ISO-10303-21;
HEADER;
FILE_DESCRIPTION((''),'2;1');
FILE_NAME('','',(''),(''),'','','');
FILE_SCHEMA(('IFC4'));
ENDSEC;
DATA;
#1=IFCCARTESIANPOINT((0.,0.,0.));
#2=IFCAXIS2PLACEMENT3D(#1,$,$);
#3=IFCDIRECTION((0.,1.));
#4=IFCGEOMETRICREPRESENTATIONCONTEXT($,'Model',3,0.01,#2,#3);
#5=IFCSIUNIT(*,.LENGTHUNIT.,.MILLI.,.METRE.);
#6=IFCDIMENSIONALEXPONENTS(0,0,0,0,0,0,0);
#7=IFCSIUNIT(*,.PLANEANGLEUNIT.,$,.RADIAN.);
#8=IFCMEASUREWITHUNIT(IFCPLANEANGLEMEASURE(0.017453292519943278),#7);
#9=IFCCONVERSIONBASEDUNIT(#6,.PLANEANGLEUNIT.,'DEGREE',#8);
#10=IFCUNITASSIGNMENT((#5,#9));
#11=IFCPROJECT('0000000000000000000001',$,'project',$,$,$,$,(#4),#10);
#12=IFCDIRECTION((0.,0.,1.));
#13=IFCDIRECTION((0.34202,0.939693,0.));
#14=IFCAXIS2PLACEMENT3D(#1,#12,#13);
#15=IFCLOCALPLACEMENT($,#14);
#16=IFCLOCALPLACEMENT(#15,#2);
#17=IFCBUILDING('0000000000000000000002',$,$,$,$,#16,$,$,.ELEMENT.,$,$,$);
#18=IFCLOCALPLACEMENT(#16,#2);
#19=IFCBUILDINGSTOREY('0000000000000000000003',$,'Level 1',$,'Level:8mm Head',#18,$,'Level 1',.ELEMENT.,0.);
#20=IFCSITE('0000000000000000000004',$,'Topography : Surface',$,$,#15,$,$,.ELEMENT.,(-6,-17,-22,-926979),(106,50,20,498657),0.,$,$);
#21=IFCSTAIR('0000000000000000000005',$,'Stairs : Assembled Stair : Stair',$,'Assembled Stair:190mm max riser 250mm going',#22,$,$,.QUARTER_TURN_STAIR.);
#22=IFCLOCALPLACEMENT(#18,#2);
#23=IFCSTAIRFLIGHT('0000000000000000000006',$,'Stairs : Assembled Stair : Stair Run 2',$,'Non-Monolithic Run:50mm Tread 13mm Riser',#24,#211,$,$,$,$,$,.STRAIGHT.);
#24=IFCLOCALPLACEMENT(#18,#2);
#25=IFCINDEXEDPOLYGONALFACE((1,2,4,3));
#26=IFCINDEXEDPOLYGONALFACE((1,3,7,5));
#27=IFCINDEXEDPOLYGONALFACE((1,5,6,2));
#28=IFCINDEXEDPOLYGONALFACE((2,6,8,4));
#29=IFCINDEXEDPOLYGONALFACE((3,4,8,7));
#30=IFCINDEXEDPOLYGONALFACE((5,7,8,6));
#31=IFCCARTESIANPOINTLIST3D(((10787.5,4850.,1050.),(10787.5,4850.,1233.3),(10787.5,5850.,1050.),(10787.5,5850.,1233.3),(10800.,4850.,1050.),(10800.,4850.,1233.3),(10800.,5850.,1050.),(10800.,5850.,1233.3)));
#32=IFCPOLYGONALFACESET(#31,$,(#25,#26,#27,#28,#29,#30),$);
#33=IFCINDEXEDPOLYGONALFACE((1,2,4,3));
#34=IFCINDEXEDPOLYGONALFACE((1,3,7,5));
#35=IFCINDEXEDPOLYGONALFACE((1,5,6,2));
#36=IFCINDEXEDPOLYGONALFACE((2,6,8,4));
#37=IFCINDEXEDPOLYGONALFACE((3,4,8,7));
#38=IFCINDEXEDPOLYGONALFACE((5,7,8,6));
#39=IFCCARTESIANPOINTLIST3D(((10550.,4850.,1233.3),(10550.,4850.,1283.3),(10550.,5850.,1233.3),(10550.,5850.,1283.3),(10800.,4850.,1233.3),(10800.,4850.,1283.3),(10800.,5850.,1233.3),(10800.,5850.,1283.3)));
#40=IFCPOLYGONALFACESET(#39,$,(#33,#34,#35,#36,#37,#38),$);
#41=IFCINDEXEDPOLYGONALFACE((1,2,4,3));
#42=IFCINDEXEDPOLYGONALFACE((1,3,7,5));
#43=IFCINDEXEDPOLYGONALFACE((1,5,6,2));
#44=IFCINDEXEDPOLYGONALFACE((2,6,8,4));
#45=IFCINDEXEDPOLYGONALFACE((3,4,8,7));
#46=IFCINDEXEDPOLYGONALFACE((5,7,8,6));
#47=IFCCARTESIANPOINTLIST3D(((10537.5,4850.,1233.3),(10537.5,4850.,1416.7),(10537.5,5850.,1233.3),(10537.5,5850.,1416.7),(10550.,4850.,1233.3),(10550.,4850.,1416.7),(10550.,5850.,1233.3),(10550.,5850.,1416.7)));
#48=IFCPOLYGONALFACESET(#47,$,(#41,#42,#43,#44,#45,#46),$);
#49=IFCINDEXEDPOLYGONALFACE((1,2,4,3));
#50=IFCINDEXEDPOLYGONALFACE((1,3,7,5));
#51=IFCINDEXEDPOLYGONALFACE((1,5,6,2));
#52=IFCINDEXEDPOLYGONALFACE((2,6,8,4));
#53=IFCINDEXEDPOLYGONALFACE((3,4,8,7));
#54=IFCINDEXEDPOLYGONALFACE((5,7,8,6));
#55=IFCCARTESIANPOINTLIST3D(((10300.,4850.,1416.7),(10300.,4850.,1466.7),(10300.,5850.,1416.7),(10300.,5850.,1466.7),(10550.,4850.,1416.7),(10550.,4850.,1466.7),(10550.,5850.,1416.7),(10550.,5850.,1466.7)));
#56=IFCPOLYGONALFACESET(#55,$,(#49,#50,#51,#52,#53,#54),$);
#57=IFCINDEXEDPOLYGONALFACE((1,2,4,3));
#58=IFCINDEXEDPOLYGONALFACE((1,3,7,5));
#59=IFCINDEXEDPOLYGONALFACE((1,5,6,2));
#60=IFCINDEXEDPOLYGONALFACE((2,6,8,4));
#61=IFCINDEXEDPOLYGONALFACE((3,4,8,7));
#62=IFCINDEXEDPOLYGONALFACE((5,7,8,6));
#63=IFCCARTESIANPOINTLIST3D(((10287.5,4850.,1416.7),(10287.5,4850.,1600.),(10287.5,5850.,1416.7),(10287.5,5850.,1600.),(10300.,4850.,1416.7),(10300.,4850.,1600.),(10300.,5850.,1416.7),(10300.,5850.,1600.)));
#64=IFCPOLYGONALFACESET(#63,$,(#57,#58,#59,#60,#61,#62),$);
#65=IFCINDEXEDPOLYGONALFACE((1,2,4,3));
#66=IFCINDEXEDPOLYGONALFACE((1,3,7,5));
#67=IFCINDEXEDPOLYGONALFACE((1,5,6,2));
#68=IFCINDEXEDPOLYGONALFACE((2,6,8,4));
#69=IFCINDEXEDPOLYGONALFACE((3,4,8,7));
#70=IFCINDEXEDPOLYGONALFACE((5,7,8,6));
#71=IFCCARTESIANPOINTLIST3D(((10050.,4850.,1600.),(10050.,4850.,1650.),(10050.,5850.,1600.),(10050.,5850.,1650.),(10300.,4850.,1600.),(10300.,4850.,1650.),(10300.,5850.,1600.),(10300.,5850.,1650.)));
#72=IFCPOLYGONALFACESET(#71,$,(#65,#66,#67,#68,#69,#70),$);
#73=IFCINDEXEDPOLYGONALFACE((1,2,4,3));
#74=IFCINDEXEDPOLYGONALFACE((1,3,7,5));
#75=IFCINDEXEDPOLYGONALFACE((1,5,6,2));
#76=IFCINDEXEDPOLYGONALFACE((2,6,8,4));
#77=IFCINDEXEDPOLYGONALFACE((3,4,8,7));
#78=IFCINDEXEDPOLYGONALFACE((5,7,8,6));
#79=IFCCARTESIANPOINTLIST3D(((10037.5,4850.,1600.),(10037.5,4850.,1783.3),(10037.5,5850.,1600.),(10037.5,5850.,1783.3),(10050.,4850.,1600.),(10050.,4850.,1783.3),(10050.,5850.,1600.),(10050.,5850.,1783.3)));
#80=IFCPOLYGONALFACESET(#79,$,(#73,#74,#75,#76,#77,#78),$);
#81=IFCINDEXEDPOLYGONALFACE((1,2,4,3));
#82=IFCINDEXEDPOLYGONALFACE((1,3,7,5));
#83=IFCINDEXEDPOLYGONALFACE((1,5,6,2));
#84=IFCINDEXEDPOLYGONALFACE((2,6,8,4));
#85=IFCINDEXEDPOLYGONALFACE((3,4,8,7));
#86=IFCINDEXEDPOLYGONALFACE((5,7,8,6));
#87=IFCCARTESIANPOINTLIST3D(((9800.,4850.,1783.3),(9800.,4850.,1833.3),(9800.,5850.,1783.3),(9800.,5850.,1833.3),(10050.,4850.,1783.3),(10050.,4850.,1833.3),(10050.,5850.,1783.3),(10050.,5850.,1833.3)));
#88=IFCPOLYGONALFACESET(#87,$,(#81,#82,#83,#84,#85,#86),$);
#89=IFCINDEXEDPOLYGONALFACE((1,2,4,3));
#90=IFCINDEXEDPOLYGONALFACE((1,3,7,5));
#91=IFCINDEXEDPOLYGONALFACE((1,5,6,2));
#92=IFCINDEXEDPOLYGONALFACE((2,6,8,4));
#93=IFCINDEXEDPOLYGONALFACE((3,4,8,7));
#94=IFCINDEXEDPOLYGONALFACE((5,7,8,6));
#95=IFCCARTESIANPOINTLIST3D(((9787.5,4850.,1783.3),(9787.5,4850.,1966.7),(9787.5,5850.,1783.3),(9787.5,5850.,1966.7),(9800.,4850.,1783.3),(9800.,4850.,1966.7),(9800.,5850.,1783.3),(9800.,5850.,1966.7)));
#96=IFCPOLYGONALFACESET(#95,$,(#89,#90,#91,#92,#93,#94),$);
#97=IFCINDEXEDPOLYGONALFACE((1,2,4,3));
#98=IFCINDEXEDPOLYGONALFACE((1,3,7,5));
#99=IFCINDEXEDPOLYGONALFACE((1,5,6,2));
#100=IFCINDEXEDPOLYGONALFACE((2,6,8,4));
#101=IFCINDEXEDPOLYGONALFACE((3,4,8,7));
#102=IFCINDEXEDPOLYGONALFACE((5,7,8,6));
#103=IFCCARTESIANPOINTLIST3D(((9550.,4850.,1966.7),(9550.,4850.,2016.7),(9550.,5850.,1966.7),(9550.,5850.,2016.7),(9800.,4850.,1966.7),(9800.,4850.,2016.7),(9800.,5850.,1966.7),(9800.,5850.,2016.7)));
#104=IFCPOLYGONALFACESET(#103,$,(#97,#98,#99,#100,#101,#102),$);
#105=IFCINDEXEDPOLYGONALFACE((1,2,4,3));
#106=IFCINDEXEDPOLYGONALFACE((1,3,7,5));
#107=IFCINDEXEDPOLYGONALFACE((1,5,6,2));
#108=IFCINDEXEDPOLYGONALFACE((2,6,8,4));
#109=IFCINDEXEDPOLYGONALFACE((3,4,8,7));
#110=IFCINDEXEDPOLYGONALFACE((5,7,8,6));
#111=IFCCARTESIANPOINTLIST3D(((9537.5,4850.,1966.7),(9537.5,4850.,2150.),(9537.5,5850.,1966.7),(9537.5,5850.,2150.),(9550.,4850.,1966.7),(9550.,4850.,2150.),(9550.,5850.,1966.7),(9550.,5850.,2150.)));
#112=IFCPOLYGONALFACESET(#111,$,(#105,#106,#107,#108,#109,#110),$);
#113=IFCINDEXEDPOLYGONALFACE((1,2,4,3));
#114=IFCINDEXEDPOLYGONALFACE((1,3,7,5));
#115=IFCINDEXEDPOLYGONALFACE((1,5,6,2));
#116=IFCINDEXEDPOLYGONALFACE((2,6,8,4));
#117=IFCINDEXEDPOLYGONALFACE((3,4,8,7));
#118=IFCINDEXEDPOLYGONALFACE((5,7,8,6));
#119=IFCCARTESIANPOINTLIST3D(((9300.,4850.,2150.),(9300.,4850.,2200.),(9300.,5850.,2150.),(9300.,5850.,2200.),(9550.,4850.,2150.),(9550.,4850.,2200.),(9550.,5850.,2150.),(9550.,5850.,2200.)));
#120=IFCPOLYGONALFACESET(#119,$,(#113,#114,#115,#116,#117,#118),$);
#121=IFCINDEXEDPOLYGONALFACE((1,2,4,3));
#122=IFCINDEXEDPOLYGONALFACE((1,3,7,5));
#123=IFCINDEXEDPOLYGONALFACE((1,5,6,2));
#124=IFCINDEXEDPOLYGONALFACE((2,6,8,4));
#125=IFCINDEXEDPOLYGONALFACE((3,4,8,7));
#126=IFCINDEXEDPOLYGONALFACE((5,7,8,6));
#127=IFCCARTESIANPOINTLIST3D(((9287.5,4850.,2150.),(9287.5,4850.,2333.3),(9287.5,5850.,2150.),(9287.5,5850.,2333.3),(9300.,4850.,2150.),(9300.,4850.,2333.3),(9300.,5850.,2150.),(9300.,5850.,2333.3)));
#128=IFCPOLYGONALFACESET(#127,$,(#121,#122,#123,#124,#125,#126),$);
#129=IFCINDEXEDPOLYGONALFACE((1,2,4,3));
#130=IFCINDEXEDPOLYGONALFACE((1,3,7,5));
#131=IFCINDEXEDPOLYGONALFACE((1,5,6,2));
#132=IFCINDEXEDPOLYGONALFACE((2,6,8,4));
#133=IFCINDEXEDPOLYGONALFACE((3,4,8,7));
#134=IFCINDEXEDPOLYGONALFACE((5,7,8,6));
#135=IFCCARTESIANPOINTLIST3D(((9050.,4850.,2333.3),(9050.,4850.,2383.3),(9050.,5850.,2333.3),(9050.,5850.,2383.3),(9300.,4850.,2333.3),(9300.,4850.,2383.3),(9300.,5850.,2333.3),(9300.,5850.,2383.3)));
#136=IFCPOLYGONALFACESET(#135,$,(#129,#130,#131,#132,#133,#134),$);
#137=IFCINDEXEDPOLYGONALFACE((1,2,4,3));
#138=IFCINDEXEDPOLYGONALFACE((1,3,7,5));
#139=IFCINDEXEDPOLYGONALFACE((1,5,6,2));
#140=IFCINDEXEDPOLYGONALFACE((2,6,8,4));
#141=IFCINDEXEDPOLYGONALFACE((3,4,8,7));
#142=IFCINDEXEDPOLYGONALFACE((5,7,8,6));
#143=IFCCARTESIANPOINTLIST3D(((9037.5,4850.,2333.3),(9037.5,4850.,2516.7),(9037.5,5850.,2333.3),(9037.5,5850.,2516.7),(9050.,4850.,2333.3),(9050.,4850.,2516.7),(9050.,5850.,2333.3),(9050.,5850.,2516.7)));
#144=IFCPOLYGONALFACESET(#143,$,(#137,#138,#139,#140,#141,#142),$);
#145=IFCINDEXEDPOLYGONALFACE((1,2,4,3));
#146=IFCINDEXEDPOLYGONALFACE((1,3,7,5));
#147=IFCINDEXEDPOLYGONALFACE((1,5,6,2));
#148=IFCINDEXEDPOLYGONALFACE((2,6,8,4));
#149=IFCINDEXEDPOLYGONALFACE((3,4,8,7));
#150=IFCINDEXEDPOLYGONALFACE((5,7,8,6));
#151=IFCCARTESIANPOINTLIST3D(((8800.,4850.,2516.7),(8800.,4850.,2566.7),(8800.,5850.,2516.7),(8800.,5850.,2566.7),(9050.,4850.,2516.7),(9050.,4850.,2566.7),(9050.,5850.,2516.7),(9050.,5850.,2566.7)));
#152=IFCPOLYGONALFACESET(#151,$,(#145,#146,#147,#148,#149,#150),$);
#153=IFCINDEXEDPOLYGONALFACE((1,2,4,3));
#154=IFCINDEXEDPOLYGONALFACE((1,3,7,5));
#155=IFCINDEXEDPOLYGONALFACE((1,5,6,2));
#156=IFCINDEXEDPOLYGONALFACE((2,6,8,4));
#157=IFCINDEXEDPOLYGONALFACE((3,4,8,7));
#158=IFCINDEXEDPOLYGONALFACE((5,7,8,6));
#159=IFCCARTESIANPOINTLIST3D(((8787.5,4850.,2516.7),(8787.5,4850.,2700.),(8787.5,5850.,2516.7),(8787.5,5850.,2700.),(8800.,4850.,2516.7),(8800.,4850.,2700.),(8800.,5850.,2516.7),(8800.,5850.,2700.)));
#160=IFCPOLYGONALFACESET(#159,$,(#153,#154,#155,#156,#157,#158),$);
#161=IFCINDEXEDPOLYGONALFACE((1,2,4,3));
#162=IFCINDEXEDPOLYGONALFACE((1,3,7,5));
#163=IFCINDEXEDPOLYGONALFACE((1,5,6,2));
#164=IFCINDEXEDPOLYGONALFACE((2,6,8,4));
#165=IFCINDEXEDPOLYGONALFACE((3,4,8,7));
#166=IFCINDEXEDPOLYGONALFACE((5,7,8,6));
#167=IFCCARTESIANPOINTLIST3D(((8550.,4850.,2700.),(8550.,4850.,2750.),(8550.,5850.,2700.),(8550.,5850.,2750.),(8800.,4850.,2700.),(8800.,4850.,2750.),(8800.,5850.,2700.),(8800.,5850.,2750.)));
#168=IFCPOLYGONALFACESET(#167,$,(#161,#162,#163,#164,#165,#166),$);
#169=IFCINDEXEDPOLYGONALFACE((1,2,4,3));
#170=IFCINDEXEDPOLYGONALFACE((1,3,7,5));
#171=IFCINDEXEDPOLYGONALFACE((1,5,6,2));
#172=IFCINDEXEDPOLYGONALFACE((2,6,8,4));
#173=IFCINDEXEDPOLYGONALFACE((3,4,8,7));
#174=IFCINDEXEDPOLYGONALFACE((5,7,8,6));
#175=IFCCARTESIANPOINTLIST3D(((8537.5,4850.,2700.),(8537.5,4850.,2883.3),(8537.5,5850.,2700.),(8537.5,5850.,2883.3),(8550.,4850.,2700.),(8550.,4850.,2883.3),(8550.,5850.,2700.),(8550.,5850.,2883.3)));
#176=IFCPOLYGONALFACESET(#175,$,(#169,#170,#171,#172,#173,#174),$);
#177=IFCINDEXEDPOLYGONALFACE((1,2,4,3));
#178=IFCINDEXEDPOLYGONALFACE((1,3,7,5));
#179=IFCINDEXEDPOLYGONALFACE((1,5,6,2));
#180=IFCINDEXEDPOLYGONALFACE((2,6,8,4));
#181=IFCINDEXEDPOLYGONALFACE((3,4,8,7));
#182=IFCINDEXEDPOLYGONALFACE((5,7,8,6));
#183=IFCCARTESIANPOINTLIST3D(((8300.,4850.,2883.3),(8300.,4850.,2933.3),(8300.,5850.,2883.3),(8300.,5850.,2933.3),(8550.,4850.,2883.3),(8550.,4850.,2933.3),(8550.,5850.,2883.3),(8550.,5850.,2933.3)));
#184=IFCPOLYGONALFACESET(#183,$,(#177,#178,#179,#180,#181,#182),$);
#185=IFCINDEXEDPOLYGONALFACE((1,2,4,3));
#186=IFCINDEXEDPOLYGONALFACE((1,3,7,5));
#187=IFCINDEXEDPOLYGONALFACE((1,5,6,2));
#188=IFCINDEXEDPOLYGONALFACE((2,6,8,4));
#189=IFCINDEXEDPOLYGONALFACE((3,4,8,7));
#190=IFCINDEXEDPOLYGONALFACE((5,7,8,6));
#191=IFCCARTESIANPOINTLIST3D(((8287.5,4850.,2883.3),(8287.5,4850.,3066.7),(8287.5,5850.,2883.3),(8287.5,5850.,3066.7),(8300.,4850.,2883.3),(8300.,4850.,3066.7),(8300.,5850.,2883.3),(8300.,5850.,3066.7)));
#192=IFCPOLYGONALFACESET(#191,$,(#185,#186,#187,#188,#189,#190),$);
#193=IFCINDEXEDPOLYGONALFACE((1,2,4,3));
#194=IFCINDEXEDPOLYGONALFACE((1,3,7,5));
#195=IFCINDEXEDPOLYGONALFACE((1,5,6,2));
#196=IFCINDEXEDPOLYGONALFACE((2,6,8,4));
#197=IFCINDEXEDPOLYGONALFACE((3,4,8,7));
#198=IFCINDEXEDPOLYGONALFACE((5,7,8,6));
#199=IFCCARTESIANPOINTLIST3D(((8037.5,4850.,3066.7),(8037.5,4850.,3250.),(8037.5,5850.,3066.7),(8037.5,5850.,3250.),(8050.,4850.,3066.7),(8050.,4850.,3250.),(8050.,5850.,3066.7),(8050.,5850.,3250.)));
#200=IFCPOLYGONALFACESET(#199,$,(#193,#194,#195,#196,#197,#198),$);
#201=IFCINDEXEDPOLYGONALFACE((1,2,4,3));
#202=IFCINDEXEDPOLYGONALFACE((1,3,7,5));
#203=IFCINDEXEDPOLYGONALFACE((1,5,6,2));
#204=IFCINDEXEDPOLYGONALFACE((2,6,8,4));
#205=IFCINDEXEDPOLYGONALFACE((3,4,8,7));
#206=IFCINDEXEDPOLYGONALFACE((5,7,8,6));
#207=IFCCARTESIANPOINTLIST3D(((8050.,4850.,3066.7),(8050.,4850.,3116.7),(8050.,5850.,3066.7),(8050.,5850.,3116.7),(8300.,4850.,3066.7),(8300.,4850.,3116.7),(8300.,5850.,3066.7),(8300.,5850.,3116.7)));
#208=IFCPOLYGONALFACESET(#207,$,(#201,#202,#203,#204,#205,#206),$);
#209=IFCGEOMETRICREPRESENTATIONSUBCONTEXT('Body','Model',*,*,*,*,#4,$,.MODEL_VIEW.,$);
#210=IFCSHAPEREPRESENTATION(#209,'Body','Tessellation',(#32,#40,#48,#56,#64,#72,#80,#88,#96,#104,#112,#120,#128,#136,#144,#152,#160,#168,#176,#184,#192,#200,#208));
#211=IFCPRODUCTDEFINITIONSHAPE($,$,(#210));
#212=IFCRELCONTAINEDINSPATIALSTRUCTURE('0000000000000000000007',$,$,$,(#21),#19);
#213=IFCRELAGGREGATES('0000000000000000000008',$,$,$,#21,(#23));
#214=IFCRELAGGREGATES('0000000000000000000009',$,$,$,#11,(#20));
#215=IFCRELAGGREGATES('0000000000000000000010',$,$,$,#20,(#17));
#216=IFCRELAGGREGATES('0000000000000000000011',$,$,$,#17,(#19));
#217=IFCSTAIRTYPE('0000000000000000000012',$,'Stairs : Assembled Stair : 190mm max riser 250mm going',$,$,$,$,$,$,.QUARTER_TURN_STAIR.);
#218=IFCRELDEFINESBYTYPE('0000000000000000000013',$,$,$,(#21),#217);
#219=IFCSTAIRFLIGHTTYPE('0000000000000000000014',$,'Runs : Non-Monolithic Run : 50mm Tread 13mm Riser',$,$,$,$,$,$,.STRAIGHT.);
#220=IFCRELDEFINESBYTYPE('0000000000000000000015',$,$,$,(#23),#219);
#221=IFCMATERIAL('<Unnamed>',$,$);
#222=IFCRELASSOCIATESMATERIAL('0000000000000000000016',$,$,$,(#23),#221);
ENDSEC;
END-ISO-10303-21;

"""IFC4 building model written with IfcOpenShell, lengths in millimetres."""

from ifc_helpers import new_model, entity, si_unit, converted_unit, direction, frame, origin, place, context, subcontext, project, spatial, indexed_curve, outline, extrude, material, type_object, element, aggregate, save


model = new_model("IFC4")

# Units and contexts
model_context = context("Model", 3, precision=0.01, world=origin(), true_north=direction((0.0, 1.0)))
body_context = subcontext(model_context, "Body", "Model", "MODEL_VIEW")
ifc_project = project(units=[si_unit("LENGTHUNIT", "METRE", prefix="MILLI"), converted_unit("PLANEANGLEUNIT", "DEGREE", entity("IfcPlaneAngleMeasure", 0.017453292519943278), si_unit("PLANEANGLEUNIT", "RADIAN"), dimensions=[0, 0, 0, 0, 0, 0, 0])], contexts=[model_context])

# Site, building, storey
site_placement = place(None, frame((0.0, 0.0, 0.0), z_axis=(0.0, 0.0, 1.0), x_axis=(0.34202, 0.939693, 0.0)))
site = spatial("IfcSite", under=ifc_project, at=site_placement, Name="Topography : Surface", CompositionType="ELEMENT", RefLatitude=(-6, -17, -22, -926979), RefLongitude=(106, 50, 20, 498657), RefElevation=0.0)
building_placement = place(site_placement, origin())
building = spatial("IfcBuilding", under=site, at=building_placement, CompositionType="ELEMENT")
storey_placement = place(building_placement, origin())
storey = spatial("IfcBuildingStorey", under=building, at=storey_placement, Name="Level 1", ObjectType="Level:8mm Head", LongName="Level 1", CompositionType="ELEMENT", Elevation=0.0)

# Shared definitions
ifc_material_1 = material(Name="<Unnamed>")

# Stair
stair_type_1 = type_object("IfcStairType", Name="Stairs : Assembled Stair : 190mm max riser 250mm going", PredefinedType="QUARTER_TURN_STAIR")
stair_1_placement = place(storey_placement, origin())
stair_1 = element("IfcStair", 1, at=stair_1_placement, inside=storey, type_object=stair_type_1, Name="Stairs : Assembled Stair : Stair", ObjectType="Assembled Stair:190mm max riser 250mm going", PredefinedType="QUARTER_TURN_STAIR")

# Stair flight
stair_flight_type_1 = type_object("IfcStairFlightType", Name="Runs : Non-Monolithic Run : 50mm Tread 13mm Riser", PredefinedType="STRAIGHT")
stair_flight_1_placement = place(stair_1_placement, frame((8037.5, 4850.0, 0.0)))
stair_flight_1 = element("IfcStairFlight", 2, at=stair_flight_1_placement, type_object=stair_flight_type_1, material=ifc_material_1, Name="Stairs : Assembled Stair : Stair Run 2", ObjectType="Non-Monolithic Run:50mm Tread 13mm Riser", PredefinedType="STRAIGHT", context=body_context, shape_type="SweptSolid", body=[
    extrude(outline(indexed_curve([(-500.0, -6.3), (500.0, -6.3), (500.0, 6.2), (-500.0, 6.2), (-500.0, -6.3)], self_intersect=False)), frame((2756.3, 500.0, 1050.0), z_axis=(0.0, 0.0, 1.0), x_axis=(0.0, -1.0, 0.0)), (0.0, 0.0, 1.0), 183.3),
    extrude(outline(indexed_curve([(-125.0, -500.0), (125.0, -500.0), (125.0, 500.0), (-125.0, 500.0), (-125.0, -500.0)], self_intersect=False)), frame((2637.5, 500.0, 1233.3)), (0.0, 0.0, 1.0), 50.0),
    extrude(outline(indexed_curve([(-500.0, -6.2), (500.0, -6.2), (500.0, 6.3), (-500.0, 6.3), (-500.0, -6.2)], self_intersect=False)), frame((2506.2, 500.0, 1233.3), z_axis=(0.0, 0.0, 1.0), x_axis=(0.0, -1.0, 0.0)), (0.0, 0.0, 1.0), 183.3),
    extrude(outline(indexed_curve([(-125.0, -500.0), (125.0, -500.0), (125.0, 500.0), (-125.0, 500.0), (-125.0, -500.0)], self_intersect=False)), frame((2387.5, 500.0, 1416.7)), (0.0, 0.0, 1.0), 50.0),
    extrude(outline(indexed_curve([(-500.0, -6.3), (500.0, -6.3), (500.0, 6.2), (-500.0, 6.2), (-500.0, -6.3)], self_intersect=False)), frame((2256.3, 500.0, 1416.7), z_axis=(0.0, 0.0, 1.0), x_axis=(0.0, -1.0, 0.0)), (0.0, 0.0, 1.0), 183.3),
    extrude(outline(indexed_curve([(-125.0, -500.0), (125.0, -500.0), (125.0, 500.0), (-125.0, 500.0), (-125.0, -500.0)], self_intersect=False)), frame((2137.5, 500.0, 1600.0)), (0.0, 0.0, 1.0), 50.0),
    extrude(outline(indexed_curve([(-500.0, -6.2), (500.0, -6.2), (500.0, 6.3), (-500.0, 6.3), (-500.0, -6.2)], self_intersect=False)), frame((2006.3, 500.0, 1600.0), z_axis=(0.0, 0.0, 1.0), x_axis=(0.0, -1.0, 0.0)), (0.0, 0.0, 1.0), 183.3),
    extrude(outline(indexed_curve([(-125.0, -500.0), (125.0, -500.0), (125.0, 500.0), (-125.0, 500.0), (-125.0, -500.0)], self_intersect=False)), frame((1887.5, 500.0, 1783.3)), (0.0, 0.0, 1.0), 50.0),
    extrude(outline(indexed_curve([(-500.0, -6.3), (500.0, -6.3), (500.0, 6.2), (-500.0, 6.2), (-500.0, -6.3)], self_intersect=False)), frame((1756.3, 500.0, 1783.3), z_axis=(0.0, 0.0, 1.0), x_axis=(0.0, -1.0, 0.0)), (0.0, 0.0, 1.0), 183.3),
    extrude(outline(indexed_curve([(-125.0, -500.0), (125.0, -500.0), (125.0, 500.0), (-125.0, 500.0), (-125.0, -500.0)], self_intersect=False)), frame((1637.5, 500.0, 1966.7)), (0.0, 0.0, 1.0), 50.0),
    extrude(outline(indexed_curve([(-500.0, -6.2), (500.0, -6.2), (500.0, 6.2), (-500.0, 6.2), (-500.0, -6.2)], self_intersect=False)), frame((1506.2, 500.0, 1966.7), z_axis=(0.0, 0.0, 1.0), x_axis=(0.0, -1.0, 0.0)), (0.0, 0.0, 1.0), 183.3),
    extrude(outline(indexed_curve([(-125.0, -500.0), (125.0, -500.0), (125.0, 500.0), (-125.0, 500.0), (-125.0, -500.0)], self_intersect=False)), frame((1387.5, 500.0, 2150.0)), (0.0, 0.0, 1.0), 50.0),
    extrude(outline(indexed_curve([(-500.0, -6.2), (500.0, -6.2), (500.0, 6.2), (-500.0, 6.2), (-500.0, -6.2)], self_intersect=False)), frame((1256.3, 500.0, 2150.0), z_axis=(0.0, 0.0, 1.0), x_axis=(0.0, -1.0, 0.0)), (0.0, 0.0, 1.0), 183.3),
    extrude(outline(indexed_curve([(-125.0, -500.0), (125.0, -500.0), (125.0, 500.0), (-125.0, 500.0), (-125.0, -500.0)], self_intersect=False)), frame((1137.5, 500.0, 2333.3)), (0.0, 0.0, 1.0), 50.0),
    extrude(outline(indexed_curve([(-500.0, -6.2), (500.0, -6.2), (500.0, 6.2), (-500.0, 6.2), (-500.0, -6.2)], self_intersect=False)), frame((1006.2, 500.0, 2333.3), z_axis=(0.0, 0.0, 1.0), x_axis=(0.0, -1.0, 0.0)), (0.0, 0.0, 1.0), 183.3),
    extrude(outline(indexed_curve([(-125.0, -500.0), (125.0, -500.0), (125.0, 500.0), (-125.0, 500.0), (-125.0, -500.0)], self_intersect=False)), frame((887.5, 500.0, 2516.7)), (0.0, 0.0, 1.0), 50.0),
    extrude(outline(indexed_curve([(-500.0, -6.2), (500.0, -6.2), (500.0, 6.2), (-500.0, 6.2), (-500.0, -6.2)], self_intersect=False)), frame((756.3, 500.0, 2516.7), z_axis=(0.0, 0.0, 1.0), x_axis=(0.0, -1.0, 0.0)), (0.0, 0.0, 1.0), 183.3),
    extrude(outline(indexed_curve([(-125.0, -500.0), (125.0, -500.0), (125.0, 500.0), (-125.0, 500.0), (-125.0, -500.0)], self_intersect=False)), frame((637.5, 500.0, 2700.0)), (0.0, 0.0, 1.0), 50.0),
    extrude(outline(indexed_curve([(-500.0, -6.2), (500.0, -6.2), (500.0, 6.2), (-500.0, 6.2), (-500.0, -6.2)], self_intersect=False)), frame((506.3, 500.0, 2700.0), z_axis=(0.0, 0.0, 1.0), x_axis=(0.0, -1.0, 0.0)), (0.0, 0.0, 1.0), 183.3),
    extrude(outline(indexed_curve([(-125.0, -500.0), (125.0, -500.0), (125.0, 500.0), (-125.0, 500.0), (-125.0, -500.0)], self_intersect=False)), frame((387.5, 500.0, 2883.3)), (0.0, 0.0, 1.0), 50.0),
    extrude(outline(indexed_curve([(-500.0, -6.2), (500.0, -6.2), (500.0, 6.2), (-500.0, 6.2), (-500.0, -6.2)], self_intersect=False)), frame((256.3, 500.0, 2883.3), z_axis=(0.0, 0.0, 1.0), x_axis=(0.0, -1.0, 0.0)), (0.0, 0.0, 1.0), 183.3),
    extrude(outline(indexed_curve([(-500.0, -6.2), (500.0, -6.2), (500.0, 6.3), (-500.0, 6.3), (-500.0, -6.2)], self_intersect=False)), frame((6.2, 500.0, 3066.7), z_axis=(0.0, 0.0, 1.0), x_axis=(0.0, -1.0, 0.0)), (0.0, 0.0, 1.0), 183.3),
    extrude(outline(indexed_curve([(-125.0, -500.0), (125.0, -500.0), (125.0, 500.0), (-125.0, 500.0), (-125.0, -500.0)], self_intersect=False)), frame((137.5, 500.0, 3066.7)), (0.0, 0.0, 1.0), 50.0),
])
aggregate(stair_1, [stair_flight_1])

save(model, "model.ifc")
